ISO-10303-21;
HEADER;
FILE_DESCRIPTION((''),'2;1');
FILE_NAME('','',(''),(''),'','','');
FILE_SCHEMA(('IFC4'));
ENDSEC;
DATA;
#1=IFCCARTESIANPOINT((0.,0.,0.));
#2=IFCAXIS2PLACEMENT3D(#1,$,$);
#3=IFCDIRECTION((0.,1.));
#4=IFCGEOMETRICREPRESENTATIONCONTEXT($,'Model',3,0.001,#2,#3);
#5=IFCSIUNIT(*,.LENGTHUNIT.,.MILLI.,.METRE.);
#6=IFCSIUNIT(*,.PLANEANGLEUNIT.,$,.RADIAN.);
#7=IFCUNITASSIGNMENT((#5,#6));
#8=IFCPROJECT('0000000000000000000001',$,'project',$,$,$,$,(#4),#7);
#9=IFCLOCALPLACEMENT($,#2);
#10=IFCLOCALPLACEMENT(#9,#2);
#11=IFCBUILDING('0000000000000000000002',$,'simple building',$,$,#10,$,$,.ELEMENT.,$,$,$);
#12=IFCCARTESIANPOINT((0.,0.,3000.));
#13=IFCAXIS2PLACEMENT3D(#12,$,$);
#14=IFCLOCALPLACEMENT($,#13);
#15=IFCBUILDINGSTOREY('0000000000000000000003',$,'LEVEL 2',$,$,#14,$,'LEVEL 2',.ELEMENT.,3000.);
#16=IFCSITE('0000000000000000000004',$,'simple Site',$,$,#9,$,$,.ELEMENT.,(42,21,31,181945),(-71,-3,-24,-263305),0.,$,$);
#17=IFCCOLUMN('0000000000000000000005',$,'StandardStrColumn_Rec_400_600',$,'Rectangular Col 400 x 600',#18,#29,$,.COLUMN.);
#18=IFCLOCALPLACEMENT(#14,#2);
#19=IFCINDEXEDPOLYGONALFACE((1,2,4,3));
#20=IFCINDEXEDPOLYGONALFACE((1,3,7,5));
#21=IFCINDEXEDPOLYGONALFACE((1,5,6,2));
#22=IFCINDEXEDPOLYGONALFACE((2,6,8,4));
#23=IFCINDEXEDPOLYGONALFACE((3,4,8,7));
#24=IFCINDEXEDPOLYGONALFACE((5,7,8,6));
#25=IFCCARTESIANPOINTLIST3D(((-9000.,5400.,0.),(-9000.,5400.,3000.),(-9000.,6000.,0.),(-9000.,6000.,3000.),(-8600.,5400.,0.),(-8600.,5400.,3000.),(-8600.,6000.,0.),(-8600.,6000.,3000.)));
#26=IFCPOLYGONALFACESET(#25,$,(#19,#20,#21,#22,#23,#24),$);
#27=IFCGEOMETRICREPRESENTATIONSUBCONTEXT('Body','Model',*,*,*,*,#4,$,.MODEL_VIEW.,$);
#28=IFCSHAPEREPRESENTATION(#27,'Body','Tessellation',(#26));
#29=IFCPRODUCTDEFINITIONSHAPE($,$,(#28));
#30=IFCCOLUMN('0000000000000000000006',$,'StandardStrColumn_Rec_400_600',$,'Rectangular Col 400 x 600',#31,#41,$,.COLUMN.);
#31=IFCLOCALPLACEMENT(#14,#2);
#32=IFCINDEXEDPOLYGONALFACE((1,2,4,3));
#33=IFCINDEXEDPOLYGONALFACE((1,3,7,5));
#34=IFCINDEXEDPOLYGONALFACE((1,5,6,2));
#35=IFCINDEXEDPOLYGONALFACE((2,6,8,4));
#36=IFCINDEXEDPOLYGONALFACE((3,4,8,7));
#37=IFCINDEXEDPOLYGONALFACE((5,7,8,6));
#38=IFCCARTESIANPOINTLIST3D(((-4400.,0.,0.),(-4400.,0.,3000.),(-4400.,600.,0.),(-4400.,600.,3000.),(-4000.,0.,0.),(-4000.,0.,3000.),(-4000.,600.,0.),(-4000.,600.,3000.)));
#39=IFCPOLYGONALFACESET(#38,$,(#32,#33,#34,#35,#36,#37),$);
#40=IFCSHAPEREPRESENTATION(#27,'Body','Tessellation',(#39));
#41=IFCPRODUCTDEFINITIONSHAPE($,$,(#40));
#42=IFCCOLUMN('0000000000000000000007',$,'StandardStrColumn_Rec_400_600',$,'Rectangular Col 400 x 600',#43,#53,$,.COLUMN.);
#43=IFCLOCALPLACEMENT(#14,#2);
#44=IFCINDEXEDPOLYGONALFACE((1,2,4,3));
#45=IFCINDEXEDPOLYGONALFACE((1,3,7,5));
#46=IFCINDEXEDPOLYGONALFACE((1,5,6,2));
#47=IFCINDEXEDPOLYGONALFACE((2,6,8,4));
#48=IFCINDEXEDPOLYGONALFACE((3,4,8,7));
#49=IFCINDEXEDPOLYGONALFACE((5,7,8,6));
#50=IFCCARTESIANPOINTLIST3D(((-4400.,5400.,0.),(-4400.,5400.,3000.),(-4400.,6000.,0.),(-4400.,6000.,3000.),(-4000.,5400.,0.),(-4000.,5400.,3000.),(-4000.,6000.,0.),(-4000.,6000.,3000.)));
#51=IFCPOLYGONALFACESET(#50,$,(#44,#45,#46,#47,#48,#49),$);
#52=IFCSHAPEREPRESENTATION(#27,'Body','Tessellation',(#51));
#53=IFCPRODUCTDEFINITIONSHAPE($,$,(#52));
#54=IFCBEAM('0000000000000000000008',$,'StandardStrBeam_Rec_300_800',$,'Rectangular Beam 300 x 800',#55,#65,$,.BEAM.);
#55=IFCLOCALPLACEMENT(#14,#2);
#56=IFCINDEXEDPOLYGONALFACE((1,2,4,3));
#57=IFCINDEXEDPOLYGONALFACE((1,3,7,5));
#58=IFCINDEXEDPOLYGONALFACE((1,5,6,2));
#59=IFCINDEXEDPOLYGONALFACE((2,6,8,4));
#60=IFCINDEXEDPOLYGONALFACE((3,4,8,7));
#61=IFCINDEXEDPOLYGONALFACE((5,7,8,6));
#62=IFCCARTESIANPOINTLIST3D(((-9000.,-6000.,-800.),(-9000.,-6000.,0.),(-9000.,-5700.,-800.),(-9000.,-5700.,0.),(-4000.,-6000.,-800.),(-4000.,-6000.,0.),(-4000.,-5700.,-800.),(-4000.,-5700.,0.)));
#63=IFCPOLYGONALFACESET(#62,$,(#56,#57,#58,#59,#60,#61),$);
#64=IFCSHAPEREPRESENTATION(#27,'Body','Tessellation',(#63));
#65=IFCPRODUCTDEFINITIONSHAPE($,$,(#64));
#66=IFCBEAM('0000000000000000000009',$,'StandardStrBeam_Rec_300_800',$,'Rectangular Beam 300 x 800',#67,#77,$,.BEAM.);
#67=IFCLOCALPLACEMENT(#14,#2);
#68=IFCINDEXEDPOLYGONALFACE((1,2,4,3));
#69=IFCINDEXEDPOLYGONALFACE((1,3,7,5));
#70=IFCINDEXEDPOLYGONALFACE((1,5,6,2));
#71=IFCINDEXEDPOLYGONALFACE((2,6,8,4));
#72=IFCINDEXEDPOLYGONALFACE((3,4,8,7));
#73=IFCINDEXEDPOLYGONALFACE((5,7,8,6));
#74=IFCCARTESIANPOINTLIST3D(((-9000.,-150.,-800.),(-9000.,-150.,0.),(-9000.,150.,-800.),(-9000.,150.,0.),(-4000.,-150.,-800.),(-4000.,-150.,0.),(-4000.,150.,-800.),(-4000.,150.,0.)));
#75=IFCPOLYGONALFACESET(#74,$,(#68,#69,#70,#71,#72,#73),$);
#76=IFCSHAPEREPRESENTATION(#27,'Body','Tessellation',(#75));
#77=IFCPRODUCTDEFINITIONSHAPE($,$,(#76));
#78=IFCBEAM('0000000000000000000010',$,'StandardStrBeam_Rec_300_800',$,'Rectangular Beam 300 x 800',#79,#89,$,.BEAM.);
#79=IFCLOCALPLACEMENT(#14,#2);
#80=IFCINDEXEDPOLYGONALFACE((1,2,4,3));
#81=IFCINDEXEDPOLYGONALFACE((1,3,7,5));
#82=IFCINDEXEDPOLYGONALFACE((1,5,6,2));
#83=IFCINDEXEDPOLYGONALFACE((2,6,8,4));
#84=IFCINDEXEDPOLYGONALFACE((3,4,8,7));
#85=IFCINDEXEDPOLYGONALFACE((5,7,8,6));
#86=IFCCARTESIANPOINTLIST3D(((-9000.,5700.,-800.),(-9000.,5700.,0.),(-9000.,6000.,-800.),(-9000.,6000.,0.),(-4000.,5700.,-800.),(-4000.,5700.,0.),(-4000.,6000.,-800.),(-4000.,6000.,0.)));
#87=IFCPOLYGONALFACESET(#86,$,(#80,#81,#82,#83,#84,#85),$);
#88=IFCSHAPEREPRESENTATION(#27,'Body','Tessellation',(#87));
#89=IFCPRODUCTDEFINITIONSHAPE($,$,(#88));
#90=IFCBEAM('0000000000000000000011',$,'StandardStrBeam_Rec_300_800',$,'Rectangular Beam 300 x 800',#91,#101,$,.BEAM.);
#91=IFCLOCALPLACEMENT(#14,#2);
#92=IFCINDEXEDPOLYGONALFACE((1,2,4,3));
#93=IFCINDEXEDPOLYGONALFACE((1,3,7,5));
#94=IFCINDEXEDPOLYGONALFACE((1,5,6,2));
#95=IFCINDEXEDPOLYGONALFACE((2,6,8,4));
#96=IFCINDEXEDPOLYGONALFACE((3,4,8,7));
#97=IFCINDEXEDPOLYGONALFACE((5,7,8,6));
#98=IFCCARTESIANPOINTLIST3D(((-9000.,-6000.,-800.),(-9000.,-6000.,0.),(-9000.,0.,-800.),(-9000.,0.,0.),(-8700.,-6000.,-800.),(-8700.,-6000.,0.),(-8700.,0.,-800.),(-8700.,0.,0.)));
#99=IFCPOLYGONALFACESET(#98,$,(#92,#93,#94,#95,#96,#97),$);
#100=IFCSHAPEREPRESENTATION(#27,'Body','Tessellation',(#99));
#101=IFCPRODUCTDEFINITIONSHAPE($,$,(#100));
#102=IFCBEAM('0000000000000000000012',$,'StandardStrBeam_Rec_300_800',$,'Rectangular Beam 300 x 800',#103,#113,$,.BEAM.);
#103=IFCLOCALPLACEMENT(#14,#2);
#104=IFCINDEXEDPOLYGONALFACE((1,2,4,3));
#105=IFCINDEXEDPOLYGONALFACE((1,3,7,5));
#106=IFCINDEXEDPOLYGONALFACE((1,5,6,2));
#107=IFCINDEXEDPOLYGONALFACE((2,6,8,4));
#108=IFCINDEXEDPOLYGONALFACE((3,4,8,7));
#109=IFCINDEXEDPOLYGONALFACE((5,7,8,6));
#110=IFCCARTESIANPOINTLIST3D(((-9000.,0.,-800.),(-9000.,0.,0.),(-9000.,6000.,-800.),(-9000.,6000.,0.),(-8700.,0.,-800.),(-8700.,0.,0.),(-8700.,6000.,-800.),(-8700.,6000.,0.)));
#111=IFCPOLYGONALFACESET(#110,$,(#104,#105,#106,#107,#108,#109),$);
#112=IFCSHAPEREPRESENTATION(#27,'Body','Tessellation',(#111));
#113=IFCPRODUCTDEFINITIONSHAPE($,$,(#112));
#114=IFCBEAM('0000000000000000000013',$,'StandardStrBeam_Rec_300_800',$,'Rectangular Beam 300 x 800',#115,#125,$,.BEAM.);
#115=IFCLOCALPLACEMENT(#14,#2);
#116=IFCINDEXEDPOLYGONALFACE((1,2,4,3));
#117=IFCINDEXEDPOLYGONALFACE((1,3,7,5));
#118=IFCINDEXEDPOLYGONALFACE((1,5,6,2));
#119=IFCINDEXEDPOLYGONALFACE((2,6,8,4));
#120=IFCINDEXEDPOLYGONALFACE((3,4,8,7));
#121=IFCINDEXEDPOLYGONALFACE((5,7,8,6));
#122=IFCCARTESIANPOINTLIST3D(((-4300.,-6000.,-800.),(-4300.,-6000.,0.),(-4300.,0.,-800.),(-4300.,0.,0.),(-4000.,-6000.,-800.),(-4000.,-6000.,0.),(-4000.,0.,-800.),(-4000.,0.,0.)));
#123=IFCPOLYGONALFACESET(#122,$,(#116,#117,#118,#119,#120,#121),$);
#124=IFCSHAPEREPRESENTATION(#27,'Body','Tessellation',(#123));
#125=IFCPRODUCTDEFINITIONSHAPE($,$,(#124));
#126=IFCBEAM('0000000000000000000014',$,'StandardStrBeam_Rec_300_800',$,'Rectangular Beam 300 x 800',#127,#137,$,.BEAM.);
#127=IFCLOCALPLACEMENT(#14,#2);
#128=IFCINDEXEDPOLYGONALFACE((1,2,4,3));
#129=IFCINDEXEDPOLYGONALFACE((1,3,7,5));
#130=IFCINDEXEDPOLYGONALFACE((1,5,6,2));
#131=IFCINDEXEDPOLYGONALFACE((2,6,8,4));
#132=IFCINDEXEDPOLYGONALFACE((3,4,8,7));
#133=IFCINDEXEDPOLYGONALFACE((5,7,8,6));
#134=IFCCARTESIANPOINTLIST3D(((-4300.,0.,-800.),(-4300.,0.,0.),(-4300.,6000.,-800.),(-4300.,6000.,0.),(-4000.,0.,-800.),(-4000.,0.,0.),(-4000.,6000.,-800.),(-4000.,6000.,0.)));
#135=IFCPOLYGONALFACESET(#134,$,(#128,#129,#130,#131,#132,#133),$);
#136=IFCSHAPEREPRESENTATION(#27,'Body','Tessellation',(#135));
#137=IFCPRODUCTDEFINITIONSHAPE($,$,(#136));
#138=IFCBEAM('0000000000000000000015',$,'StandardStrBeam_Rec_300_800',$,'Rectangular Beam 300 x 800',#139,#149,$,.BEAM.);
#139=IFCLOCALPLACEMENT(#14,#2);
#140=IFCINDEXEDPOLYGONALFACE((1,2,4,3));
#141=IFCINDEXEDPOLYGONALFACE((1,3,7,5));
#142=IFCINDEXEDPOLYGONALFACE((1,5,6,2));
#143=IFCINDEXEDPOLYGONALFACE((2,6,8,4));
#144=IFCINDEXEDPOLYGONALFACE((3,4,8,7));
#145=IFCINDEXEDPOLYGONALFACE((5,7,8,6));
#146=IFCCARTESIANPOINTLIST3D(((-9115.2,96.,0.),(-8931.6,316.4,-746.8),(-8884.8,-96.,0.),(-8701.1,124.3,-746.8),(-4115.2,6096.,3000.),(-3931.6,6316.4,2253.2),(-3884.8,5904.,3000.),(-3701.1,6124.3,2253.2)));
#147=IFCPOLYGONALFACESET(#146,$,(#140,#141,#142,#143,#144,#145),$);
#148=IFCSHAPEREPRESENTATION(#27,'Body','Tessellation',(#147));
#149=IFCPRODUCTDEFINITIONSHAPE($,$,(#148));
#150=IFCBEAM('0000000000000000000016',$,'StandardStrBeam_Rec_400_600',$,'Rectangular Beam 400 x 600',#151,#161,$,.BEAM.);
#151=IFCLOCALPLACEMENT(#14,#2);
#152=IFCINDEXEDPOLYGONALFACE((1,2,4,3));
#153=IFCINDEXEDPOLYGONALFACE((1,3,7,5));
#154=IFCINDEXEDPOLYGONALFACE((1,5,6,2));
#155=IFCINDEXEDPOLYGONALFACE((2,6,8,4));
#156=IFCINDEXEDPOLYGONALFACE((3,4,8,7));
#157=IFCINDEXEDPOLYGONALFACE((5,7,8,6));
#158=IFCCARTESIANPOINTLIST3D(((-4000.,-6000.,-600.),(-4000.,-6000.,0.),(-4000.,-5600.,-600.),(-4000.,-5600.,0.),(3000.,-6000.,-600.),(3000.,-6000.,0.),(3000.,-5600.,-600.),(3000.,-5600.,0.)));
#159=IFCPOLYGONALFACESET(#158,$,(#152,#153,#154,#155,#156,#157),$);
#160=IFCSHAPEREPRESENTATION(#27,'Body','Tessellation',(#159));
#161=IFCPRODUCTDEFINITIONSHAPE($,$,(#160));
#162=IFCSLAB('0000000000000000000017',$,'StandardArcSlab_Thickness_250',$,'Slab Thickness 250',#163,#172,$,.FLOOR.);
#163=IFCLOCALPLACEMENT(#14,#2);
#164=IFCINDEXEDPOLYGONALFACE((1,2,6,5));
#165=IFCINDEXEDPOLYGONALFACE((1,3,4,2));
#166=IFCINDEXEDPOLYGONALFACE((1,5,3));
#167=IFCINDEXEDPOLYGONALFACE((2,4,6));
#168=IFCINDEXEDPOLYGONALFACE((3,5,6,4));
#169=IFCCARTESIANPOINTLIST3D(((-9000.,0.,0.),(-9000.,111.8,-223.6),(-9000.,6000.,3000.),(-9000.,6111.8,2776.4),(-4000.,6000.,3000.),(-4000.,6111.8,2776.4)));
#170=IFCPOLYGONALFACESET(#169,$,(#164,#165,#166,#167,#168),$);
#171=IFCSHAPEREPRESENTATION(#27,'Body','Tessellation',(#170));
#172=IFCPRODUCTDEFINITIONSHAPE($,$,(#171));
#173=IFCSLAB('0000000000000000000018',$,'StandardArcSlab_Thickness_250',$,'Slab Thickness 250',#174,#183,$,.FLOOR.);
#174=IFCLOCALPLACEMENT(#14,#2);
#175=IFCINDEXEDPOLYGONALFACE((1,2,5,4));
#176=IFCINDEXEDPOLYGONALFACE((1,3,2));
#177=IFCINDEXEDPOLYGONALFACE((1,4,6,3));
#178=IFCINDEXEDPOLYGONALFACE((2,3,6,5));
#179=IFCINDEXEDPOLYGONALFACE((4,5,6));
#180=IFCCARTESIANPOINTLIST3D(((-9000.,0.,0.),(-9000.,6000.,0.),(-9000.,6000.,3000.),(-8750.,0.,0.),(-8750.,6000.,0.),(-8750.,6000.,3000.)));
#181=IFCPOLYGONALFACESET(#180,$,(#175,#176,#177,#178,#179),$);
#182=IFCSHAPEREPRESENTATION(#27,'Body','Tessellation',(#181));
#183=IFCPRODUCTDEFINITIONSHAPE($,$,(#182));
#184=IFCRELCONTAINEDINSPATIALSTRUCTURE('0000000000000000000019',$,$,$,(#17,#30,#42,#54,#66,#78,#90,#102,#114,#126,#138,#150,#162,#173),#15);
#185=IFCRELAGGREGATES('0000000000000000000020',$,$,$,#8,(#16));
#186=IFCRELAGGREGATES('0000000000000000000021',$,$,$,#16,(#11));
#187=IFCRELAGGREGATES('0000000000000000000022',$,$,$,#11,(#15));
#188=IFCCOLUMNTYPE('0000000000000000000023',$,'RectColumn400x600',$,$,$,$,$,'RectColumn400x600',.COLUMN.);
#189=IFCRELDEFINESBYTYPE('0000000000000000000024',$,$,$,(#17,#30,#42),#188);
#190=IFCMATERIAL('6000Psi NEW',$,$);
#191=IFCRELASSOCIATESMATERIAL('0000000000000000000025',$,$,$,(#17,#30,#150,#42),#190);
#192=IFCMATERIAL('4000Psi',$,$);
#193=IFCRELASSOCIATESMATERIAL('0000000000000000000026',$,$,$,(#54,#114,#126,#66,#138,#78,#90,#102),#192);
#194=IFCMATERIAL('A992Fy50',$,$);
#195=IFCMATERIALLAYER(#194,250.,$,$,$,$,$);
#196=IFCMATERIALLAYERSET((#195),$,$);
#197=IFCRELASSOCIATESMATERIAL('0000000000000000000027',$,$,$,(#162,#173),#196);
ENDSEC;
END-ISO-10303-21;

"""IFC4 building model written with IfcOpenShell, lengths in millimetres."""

from ifc_helpers import new_model, si_unit, direction, frame, origin, origin_with_axes, origin_2d_with_axis, place, context, subcontext, project, spatial, polyline, rectangle, outline, extrude, material, layer, layer_set, layer_usage, material_profile, profile_set, profile_usage, type_object, element, save


model = new_model("IFC4")

# Units and contexts
model_context = context("Model", 3, precision=0.001, world=origin(), true_north=direction((0.0, 1.0)))
body_context = subcontext(model_context, "Body", "Model", "MODEL_VIEW")
ifc_project = project(units=[si_unit("LENGTHUNIT", "METRE", prefix="MILLI"), si_unit("PLANEANGLEUNIT", "RADIAN")], contexts=[model_context])

# Site, building, storey
site_placement = place(None, origin())
site = spatial("IfcSite", under=ifc_project, at=site_placement, Name="simple Site", CompositionType="ELEMENT", RefLatitude=(42, 21, 31, 181945), RefLongitude=(-71, -3, -24, -263305), RefElevation=0.0)
building_placement = place(site_placement, origin())
building = spatial("IfcBuilding", under=site, at=building_placement, Name="simple building", CompositionType="ELEMENT")
storey_placement = place(None, frame((0.0, 0.0, 3000.0)))
storey = spatial("IfcBuildingStorey", under=building, at=storey_placement, Name="LEVEL 2", LongName="LEVEL 2", CompositionType="ELEMENT", Elevation=3000.0)

# Columns
ifc_material_1 = material(Name="6000Psi NEW")
ifc_material_profile_1 = material_profile(ifc_material_1, rectangle(XDim=400.0, YDim=600.0, at=origin_2d_with_axis()))
ifc_profile_set_1 = profile_set([ifc_material_profile_1])
ifc_profile_usage_1 = profile_usage(ifc_profile_set_1, cardinal=1)
column_type = type_object("IfcColumnType", Name="RectColumn400x600", ElementType="RectColumn400x600", PredefinedType="COLUMN")
column_1_placement = place(None, frame((-8800.0, 5700.0, 3000.0), z_axis=(0.0, 0.0, 1.0), x_axis=(1.0, 0.0, 0.0)))
element("IfcColumn", 1, at=column_1_placement, inside=storey, type_object=column_type, material=ifc_profile_usage_1, Name="StandardStrColumn_Rec_400_600", ObjectType="Rectangular Col 400 x 600", PredefinedType="COLUMN", context=body_context, shape_type="SweptSolid", body=[
    extrude(rectangle(XDim=400.0, YDim=600.0, at=origin_2d_with_axis()), origin_with_axes(), (0.0, 0.0, 1.0), 3000.0),
])
ifc_profile_usage_2 = profile_usage(ifc_profile_set_1, cardinal=9)
column_2_placement = place(None, frame((-4200.0, 300.0, 3000.0), z_axis=(0.0, 0.0, 1.0), x_axis=(1.0, 0.0, 0.0)))
element("IfcColumn", 2, at=column_2_placement, inside=storey, type_object=column_type, material=ifc_profile_usage_2, Name="StandardStrColumn_Rec_400_600", ObjectType="Rectangular Col 400 x 600", PredefinedType="COLUMN", context=body_context, shape_type="SweptSolid", body=[
    extrude(rectangle(XDim=400.0, YDim=600.0, at=origin_2d_with_axis()), origin_with_axes(), (0.0, 0.0, 1.0), 3000.0),
])
ifc_profile_usage_3 = profile_usage(ifc_profile_set_1, cardinal=3)
column_3_placement = place(None, frame((-4200.0, 5700.0, 3000.0), z_axis=(0.0, 0.0, 1.0), x_axis=(1.0, 0.0, 0.0)))
element("IfcColumn", 3, at=column_3_placement, inside=storey, type_object=column_type, material=ifc_profile_usage_3, Name="StandardStrColumn_Rec_400_600", ObjectType="Rectangular Col 400 x 600", PredefinedType="COLUMN", context=body_context, shape_type="SweptSolid", body=[
    extrude(rectangle(XDim=400.0, YDim=600.0, at=origin_2d_with_axis()), origin_with_axes(), (0.0, 0.0, 1.0), 3000.0),
])

# Beams
ifc_material_2 = material(Name="4000Psi")
ifc_material_profile_2 = material_profile(ifc_material_2, rectangle(XDim=300.0, YDim=800.0, at=origin_2d_with_axis()))
ifc_profile_set_2 = profile_set([ifc_material_profile_2])
ifc_profile_usage_4 = profile_usage(ifc_profile_set_2, cardinal=9)
beam_1_placement = place(None, frame((-9000.0, -5850.0, 2600.0), z_axis=(1.0, 0.0, 0.0), x_axis=(0.0, -1.0, 0.0)))
element("IfcBeam", 4, at=beam_1_placement, inside=storey, material=ifc_profile_usage_4, Name="StandardStrBeam_Rec_300_800", ObjectType="Rectangular Beam 300 x 800", PredefinedType="BEAM", context=body_context, shape_type="SweptSolid", body=[
    extrude(rectangle(XDim=300.0, YDim=800.0, at=origin_2d_with_axis()), origin_with_axes(), (0.0, 0.0, 1.0), 5000.0),
])
ifc_profile_usage_5 = profile_usage(ifc_profile_set_2, cardinal=8)
beam_2_placement = place(None, frame((-9000.0, 0.0, 2600.0), z_axis=(1.0, 0.0, 0.0), x_axis=(0.0, -1.0, 0.0)))
element("IfcBeam", 5, at=beam_2_placement, inside=storey, material=ifc_profile_usage_5, Name="StandardStrBeam_Rec_300_800", ObjectType="Rectangular Beam 300 x 800", PredefinedType="BEAM", context=body_context, shape_type="SweptSolid", body=[
    extrude(rectangle(XDim=300.0, YDim=800.0, at=origin_2d_with_axis()), origin_with_axes(), (0.0, 0.0, 1.0), 5000.0),
])
ifc_profile_usage_6 = profile_usage(ifc_profile_set_2, cardinal=7)
beam_3_placement = place(None, frame((-9000.0, 5850.0, 2600.0), z_axis=(1.0, 0.0, 0.0), x_axis=(0.0, -1.0, 0.0)))
element("IfcBeam", 6, at=beam_3_placement, inside=storey, material=ifc_profile_usage_6, Name="StandardStrBeam_Rec_300_800", ObjectType="Rectangular Beam 300 x 800", PredefinedType="BEAM", context=body_context, shape_type="SweptSolid", body=[
    extrude(rectangle(XDim=300.0, YDim=800.0, at=origin_2d_with_axis()), origin_with_axes(), (0.0, 0.0, 1.0), 5000.0),
])
for number, where, z_axis, x_axis, name in (
    (7, (-8850.0, -6000.0, 2600.0), (0.0, 1.0, 0.0), (1.0, 0.0, 0.0), "StandardStrBeam_Rec_300_800"),
    (8, (-8850.0, 0.0, 2600.0), (0.0, 1.0, 0.0), (1.0, 0.0, 0.0), "StandardStrBeam_Rec_300_800"),
):
    element("IfcBeam", number, at=place(None, frame(where, z_axis=z_axis, x_axis=x_axis)), inside=storey, material=ifc_profile_usage_6, Name=name, ObjectType="Rectangular Beam 300 x 800", PredefinedType="BEAM", context=body_context, shape_type="SweptSolid", body=[
        extrude(rectangle(XDim=300.0, YDim=800.0, at=origin_2d_with_axis()), origin_with_axes(), (0.0, 0.0, 1.0), 6000.0),
    ])
for number, where, z_axis, x_axis, name in (
    (9, (-4150.0, -6000.0, 2600.0), (0.0, 1.0, 0.0), (1.0, 0.0, 0.0), "StandardStrBeam_Rec_300_800"),
    (10, (-4150.0, 0.0, 2600.0), (0.0, 1.0, 0.0), (1.0, 0.0, 0.0), "StandardStrBeam_Rec_300_800"),
):
    element("IfcBeam", number, at=place(None, frame(where, z_axis=z_axis, x_axis=x_axis)), inside=storey, material=ifc_profile_usage_4, Name=name, ObjectType="Rectangular Beam 300 x 800", PredefinedType="BEAM", context=body_context, shape_type="SweptSolid", body=[
        extrude(rectangle(XDim=300.0, YDim=800.0, at=origin_2d_with_axis()), origin_with_axes(), (0.0, 0.0, 1.0), 6000.0),
    ])
beam_4_placement = place(None, frame((-8908.2, 110.2, 2626.6), z_axis=(0.597614, 0.717137, 0.358569), x_axis=(0.768221, -0.640184, 0.0)))
element("IfcBeam", 11, at=beam_4_placement, inside=storey, material=ifc_profile_usage_5, Name="StandardStrBeam_Rec_300_800", ObjectType="Rectangular Beam 300 x 800", PredefinedType="BEAM", context=body_context, shape_type="SweptSolid", body=[
    extrude(rectangle(XDim=300.0, YDim=800.0, at=origin_2d_with_axis()), origin_with_axes(), (0.0, 0.0, 1.0), 8366.6),
])
beam_5_placement = place(None, frame((-4000.0, -5800.0, 2700.0), z_axis=(1.0, 0.0, 0.0), x_axis=(0.0, -1.0, 0.0)))
element("IfcBeam", 12, at=beam_5_placement, inside=storey, material=ifc_profile_usage_2, Name="StandardStrBeam_Rec_400_600", ObjectType="Rectangular Beam 400 x 600", PredefinedType="BEAM", context=body_context, shape_type="SweptSolid", body=[
    extrude(rectangle(XDim=400.0, YDim=600.0, at=origin_2d_with_axis()), origin_with_axes(), (0.0, 0.0, 1.0), 7000.0),
])

# Slabs
ifc_material_3 = material(Name="A992Fy50")
ifc_layer = layer(ifc_material_3, 250.0)
ifc_layer_set = layer_set([ifc_layer])
ifc_layer_usage = layer_usage(ifc_layer_set, "AXIS3", "POSITIVE", -250.0)
slab_1_placement = place(None, frame((-9000.0, 6111.8, 5776.4), z_axis=(0.0, -0.447214, 0.894427), x_axis=(0.0, -0.894427, -0.447214)))
element("IfcSlab", 13, at=slab_1_placement, inside=storey, material=ifc_layer_usage, Name="StandardArcSlab_Thickness_250", ObjectType="Slab Thickness 250", PredefinedType="FLOOR", context=body_context, shape_type="SweptSolid", body=[
    extrude(outline(polyline([(0.0, 0.0), (6708.2, 0.0), (0.0, 5000.0), (0.0, 0.0)])), origin_with_axes(), (0.0, 0.0, 1.0), 250.0),
])
slab_2_placement = place(None, frame((-8750.0, 6000.0, 3000.0), z_axis=(-1.0, 0.0, 0.0), x_axis=(0.0, -1.0, 0.0)))
element("IfcSlab", 14, at=slab_2_placement, inside=storey, material=ifc_layer_usage, Name="StandardArcSlab_Thickness_250", ObjectType="Slab Thickness 250", PredefinedType="FLOOR", context=body_context, shape_type="SweptSolid", body=[
    extrude(outline(polyline([(0.0, 0.0), (6000.0, 0.0), (0.0, 3000.0), (0.0, 0.0)])), origin_with_axes(), (0.0, 0.0, 1.0), 250.0),
])

save(model, "model.ifc")
